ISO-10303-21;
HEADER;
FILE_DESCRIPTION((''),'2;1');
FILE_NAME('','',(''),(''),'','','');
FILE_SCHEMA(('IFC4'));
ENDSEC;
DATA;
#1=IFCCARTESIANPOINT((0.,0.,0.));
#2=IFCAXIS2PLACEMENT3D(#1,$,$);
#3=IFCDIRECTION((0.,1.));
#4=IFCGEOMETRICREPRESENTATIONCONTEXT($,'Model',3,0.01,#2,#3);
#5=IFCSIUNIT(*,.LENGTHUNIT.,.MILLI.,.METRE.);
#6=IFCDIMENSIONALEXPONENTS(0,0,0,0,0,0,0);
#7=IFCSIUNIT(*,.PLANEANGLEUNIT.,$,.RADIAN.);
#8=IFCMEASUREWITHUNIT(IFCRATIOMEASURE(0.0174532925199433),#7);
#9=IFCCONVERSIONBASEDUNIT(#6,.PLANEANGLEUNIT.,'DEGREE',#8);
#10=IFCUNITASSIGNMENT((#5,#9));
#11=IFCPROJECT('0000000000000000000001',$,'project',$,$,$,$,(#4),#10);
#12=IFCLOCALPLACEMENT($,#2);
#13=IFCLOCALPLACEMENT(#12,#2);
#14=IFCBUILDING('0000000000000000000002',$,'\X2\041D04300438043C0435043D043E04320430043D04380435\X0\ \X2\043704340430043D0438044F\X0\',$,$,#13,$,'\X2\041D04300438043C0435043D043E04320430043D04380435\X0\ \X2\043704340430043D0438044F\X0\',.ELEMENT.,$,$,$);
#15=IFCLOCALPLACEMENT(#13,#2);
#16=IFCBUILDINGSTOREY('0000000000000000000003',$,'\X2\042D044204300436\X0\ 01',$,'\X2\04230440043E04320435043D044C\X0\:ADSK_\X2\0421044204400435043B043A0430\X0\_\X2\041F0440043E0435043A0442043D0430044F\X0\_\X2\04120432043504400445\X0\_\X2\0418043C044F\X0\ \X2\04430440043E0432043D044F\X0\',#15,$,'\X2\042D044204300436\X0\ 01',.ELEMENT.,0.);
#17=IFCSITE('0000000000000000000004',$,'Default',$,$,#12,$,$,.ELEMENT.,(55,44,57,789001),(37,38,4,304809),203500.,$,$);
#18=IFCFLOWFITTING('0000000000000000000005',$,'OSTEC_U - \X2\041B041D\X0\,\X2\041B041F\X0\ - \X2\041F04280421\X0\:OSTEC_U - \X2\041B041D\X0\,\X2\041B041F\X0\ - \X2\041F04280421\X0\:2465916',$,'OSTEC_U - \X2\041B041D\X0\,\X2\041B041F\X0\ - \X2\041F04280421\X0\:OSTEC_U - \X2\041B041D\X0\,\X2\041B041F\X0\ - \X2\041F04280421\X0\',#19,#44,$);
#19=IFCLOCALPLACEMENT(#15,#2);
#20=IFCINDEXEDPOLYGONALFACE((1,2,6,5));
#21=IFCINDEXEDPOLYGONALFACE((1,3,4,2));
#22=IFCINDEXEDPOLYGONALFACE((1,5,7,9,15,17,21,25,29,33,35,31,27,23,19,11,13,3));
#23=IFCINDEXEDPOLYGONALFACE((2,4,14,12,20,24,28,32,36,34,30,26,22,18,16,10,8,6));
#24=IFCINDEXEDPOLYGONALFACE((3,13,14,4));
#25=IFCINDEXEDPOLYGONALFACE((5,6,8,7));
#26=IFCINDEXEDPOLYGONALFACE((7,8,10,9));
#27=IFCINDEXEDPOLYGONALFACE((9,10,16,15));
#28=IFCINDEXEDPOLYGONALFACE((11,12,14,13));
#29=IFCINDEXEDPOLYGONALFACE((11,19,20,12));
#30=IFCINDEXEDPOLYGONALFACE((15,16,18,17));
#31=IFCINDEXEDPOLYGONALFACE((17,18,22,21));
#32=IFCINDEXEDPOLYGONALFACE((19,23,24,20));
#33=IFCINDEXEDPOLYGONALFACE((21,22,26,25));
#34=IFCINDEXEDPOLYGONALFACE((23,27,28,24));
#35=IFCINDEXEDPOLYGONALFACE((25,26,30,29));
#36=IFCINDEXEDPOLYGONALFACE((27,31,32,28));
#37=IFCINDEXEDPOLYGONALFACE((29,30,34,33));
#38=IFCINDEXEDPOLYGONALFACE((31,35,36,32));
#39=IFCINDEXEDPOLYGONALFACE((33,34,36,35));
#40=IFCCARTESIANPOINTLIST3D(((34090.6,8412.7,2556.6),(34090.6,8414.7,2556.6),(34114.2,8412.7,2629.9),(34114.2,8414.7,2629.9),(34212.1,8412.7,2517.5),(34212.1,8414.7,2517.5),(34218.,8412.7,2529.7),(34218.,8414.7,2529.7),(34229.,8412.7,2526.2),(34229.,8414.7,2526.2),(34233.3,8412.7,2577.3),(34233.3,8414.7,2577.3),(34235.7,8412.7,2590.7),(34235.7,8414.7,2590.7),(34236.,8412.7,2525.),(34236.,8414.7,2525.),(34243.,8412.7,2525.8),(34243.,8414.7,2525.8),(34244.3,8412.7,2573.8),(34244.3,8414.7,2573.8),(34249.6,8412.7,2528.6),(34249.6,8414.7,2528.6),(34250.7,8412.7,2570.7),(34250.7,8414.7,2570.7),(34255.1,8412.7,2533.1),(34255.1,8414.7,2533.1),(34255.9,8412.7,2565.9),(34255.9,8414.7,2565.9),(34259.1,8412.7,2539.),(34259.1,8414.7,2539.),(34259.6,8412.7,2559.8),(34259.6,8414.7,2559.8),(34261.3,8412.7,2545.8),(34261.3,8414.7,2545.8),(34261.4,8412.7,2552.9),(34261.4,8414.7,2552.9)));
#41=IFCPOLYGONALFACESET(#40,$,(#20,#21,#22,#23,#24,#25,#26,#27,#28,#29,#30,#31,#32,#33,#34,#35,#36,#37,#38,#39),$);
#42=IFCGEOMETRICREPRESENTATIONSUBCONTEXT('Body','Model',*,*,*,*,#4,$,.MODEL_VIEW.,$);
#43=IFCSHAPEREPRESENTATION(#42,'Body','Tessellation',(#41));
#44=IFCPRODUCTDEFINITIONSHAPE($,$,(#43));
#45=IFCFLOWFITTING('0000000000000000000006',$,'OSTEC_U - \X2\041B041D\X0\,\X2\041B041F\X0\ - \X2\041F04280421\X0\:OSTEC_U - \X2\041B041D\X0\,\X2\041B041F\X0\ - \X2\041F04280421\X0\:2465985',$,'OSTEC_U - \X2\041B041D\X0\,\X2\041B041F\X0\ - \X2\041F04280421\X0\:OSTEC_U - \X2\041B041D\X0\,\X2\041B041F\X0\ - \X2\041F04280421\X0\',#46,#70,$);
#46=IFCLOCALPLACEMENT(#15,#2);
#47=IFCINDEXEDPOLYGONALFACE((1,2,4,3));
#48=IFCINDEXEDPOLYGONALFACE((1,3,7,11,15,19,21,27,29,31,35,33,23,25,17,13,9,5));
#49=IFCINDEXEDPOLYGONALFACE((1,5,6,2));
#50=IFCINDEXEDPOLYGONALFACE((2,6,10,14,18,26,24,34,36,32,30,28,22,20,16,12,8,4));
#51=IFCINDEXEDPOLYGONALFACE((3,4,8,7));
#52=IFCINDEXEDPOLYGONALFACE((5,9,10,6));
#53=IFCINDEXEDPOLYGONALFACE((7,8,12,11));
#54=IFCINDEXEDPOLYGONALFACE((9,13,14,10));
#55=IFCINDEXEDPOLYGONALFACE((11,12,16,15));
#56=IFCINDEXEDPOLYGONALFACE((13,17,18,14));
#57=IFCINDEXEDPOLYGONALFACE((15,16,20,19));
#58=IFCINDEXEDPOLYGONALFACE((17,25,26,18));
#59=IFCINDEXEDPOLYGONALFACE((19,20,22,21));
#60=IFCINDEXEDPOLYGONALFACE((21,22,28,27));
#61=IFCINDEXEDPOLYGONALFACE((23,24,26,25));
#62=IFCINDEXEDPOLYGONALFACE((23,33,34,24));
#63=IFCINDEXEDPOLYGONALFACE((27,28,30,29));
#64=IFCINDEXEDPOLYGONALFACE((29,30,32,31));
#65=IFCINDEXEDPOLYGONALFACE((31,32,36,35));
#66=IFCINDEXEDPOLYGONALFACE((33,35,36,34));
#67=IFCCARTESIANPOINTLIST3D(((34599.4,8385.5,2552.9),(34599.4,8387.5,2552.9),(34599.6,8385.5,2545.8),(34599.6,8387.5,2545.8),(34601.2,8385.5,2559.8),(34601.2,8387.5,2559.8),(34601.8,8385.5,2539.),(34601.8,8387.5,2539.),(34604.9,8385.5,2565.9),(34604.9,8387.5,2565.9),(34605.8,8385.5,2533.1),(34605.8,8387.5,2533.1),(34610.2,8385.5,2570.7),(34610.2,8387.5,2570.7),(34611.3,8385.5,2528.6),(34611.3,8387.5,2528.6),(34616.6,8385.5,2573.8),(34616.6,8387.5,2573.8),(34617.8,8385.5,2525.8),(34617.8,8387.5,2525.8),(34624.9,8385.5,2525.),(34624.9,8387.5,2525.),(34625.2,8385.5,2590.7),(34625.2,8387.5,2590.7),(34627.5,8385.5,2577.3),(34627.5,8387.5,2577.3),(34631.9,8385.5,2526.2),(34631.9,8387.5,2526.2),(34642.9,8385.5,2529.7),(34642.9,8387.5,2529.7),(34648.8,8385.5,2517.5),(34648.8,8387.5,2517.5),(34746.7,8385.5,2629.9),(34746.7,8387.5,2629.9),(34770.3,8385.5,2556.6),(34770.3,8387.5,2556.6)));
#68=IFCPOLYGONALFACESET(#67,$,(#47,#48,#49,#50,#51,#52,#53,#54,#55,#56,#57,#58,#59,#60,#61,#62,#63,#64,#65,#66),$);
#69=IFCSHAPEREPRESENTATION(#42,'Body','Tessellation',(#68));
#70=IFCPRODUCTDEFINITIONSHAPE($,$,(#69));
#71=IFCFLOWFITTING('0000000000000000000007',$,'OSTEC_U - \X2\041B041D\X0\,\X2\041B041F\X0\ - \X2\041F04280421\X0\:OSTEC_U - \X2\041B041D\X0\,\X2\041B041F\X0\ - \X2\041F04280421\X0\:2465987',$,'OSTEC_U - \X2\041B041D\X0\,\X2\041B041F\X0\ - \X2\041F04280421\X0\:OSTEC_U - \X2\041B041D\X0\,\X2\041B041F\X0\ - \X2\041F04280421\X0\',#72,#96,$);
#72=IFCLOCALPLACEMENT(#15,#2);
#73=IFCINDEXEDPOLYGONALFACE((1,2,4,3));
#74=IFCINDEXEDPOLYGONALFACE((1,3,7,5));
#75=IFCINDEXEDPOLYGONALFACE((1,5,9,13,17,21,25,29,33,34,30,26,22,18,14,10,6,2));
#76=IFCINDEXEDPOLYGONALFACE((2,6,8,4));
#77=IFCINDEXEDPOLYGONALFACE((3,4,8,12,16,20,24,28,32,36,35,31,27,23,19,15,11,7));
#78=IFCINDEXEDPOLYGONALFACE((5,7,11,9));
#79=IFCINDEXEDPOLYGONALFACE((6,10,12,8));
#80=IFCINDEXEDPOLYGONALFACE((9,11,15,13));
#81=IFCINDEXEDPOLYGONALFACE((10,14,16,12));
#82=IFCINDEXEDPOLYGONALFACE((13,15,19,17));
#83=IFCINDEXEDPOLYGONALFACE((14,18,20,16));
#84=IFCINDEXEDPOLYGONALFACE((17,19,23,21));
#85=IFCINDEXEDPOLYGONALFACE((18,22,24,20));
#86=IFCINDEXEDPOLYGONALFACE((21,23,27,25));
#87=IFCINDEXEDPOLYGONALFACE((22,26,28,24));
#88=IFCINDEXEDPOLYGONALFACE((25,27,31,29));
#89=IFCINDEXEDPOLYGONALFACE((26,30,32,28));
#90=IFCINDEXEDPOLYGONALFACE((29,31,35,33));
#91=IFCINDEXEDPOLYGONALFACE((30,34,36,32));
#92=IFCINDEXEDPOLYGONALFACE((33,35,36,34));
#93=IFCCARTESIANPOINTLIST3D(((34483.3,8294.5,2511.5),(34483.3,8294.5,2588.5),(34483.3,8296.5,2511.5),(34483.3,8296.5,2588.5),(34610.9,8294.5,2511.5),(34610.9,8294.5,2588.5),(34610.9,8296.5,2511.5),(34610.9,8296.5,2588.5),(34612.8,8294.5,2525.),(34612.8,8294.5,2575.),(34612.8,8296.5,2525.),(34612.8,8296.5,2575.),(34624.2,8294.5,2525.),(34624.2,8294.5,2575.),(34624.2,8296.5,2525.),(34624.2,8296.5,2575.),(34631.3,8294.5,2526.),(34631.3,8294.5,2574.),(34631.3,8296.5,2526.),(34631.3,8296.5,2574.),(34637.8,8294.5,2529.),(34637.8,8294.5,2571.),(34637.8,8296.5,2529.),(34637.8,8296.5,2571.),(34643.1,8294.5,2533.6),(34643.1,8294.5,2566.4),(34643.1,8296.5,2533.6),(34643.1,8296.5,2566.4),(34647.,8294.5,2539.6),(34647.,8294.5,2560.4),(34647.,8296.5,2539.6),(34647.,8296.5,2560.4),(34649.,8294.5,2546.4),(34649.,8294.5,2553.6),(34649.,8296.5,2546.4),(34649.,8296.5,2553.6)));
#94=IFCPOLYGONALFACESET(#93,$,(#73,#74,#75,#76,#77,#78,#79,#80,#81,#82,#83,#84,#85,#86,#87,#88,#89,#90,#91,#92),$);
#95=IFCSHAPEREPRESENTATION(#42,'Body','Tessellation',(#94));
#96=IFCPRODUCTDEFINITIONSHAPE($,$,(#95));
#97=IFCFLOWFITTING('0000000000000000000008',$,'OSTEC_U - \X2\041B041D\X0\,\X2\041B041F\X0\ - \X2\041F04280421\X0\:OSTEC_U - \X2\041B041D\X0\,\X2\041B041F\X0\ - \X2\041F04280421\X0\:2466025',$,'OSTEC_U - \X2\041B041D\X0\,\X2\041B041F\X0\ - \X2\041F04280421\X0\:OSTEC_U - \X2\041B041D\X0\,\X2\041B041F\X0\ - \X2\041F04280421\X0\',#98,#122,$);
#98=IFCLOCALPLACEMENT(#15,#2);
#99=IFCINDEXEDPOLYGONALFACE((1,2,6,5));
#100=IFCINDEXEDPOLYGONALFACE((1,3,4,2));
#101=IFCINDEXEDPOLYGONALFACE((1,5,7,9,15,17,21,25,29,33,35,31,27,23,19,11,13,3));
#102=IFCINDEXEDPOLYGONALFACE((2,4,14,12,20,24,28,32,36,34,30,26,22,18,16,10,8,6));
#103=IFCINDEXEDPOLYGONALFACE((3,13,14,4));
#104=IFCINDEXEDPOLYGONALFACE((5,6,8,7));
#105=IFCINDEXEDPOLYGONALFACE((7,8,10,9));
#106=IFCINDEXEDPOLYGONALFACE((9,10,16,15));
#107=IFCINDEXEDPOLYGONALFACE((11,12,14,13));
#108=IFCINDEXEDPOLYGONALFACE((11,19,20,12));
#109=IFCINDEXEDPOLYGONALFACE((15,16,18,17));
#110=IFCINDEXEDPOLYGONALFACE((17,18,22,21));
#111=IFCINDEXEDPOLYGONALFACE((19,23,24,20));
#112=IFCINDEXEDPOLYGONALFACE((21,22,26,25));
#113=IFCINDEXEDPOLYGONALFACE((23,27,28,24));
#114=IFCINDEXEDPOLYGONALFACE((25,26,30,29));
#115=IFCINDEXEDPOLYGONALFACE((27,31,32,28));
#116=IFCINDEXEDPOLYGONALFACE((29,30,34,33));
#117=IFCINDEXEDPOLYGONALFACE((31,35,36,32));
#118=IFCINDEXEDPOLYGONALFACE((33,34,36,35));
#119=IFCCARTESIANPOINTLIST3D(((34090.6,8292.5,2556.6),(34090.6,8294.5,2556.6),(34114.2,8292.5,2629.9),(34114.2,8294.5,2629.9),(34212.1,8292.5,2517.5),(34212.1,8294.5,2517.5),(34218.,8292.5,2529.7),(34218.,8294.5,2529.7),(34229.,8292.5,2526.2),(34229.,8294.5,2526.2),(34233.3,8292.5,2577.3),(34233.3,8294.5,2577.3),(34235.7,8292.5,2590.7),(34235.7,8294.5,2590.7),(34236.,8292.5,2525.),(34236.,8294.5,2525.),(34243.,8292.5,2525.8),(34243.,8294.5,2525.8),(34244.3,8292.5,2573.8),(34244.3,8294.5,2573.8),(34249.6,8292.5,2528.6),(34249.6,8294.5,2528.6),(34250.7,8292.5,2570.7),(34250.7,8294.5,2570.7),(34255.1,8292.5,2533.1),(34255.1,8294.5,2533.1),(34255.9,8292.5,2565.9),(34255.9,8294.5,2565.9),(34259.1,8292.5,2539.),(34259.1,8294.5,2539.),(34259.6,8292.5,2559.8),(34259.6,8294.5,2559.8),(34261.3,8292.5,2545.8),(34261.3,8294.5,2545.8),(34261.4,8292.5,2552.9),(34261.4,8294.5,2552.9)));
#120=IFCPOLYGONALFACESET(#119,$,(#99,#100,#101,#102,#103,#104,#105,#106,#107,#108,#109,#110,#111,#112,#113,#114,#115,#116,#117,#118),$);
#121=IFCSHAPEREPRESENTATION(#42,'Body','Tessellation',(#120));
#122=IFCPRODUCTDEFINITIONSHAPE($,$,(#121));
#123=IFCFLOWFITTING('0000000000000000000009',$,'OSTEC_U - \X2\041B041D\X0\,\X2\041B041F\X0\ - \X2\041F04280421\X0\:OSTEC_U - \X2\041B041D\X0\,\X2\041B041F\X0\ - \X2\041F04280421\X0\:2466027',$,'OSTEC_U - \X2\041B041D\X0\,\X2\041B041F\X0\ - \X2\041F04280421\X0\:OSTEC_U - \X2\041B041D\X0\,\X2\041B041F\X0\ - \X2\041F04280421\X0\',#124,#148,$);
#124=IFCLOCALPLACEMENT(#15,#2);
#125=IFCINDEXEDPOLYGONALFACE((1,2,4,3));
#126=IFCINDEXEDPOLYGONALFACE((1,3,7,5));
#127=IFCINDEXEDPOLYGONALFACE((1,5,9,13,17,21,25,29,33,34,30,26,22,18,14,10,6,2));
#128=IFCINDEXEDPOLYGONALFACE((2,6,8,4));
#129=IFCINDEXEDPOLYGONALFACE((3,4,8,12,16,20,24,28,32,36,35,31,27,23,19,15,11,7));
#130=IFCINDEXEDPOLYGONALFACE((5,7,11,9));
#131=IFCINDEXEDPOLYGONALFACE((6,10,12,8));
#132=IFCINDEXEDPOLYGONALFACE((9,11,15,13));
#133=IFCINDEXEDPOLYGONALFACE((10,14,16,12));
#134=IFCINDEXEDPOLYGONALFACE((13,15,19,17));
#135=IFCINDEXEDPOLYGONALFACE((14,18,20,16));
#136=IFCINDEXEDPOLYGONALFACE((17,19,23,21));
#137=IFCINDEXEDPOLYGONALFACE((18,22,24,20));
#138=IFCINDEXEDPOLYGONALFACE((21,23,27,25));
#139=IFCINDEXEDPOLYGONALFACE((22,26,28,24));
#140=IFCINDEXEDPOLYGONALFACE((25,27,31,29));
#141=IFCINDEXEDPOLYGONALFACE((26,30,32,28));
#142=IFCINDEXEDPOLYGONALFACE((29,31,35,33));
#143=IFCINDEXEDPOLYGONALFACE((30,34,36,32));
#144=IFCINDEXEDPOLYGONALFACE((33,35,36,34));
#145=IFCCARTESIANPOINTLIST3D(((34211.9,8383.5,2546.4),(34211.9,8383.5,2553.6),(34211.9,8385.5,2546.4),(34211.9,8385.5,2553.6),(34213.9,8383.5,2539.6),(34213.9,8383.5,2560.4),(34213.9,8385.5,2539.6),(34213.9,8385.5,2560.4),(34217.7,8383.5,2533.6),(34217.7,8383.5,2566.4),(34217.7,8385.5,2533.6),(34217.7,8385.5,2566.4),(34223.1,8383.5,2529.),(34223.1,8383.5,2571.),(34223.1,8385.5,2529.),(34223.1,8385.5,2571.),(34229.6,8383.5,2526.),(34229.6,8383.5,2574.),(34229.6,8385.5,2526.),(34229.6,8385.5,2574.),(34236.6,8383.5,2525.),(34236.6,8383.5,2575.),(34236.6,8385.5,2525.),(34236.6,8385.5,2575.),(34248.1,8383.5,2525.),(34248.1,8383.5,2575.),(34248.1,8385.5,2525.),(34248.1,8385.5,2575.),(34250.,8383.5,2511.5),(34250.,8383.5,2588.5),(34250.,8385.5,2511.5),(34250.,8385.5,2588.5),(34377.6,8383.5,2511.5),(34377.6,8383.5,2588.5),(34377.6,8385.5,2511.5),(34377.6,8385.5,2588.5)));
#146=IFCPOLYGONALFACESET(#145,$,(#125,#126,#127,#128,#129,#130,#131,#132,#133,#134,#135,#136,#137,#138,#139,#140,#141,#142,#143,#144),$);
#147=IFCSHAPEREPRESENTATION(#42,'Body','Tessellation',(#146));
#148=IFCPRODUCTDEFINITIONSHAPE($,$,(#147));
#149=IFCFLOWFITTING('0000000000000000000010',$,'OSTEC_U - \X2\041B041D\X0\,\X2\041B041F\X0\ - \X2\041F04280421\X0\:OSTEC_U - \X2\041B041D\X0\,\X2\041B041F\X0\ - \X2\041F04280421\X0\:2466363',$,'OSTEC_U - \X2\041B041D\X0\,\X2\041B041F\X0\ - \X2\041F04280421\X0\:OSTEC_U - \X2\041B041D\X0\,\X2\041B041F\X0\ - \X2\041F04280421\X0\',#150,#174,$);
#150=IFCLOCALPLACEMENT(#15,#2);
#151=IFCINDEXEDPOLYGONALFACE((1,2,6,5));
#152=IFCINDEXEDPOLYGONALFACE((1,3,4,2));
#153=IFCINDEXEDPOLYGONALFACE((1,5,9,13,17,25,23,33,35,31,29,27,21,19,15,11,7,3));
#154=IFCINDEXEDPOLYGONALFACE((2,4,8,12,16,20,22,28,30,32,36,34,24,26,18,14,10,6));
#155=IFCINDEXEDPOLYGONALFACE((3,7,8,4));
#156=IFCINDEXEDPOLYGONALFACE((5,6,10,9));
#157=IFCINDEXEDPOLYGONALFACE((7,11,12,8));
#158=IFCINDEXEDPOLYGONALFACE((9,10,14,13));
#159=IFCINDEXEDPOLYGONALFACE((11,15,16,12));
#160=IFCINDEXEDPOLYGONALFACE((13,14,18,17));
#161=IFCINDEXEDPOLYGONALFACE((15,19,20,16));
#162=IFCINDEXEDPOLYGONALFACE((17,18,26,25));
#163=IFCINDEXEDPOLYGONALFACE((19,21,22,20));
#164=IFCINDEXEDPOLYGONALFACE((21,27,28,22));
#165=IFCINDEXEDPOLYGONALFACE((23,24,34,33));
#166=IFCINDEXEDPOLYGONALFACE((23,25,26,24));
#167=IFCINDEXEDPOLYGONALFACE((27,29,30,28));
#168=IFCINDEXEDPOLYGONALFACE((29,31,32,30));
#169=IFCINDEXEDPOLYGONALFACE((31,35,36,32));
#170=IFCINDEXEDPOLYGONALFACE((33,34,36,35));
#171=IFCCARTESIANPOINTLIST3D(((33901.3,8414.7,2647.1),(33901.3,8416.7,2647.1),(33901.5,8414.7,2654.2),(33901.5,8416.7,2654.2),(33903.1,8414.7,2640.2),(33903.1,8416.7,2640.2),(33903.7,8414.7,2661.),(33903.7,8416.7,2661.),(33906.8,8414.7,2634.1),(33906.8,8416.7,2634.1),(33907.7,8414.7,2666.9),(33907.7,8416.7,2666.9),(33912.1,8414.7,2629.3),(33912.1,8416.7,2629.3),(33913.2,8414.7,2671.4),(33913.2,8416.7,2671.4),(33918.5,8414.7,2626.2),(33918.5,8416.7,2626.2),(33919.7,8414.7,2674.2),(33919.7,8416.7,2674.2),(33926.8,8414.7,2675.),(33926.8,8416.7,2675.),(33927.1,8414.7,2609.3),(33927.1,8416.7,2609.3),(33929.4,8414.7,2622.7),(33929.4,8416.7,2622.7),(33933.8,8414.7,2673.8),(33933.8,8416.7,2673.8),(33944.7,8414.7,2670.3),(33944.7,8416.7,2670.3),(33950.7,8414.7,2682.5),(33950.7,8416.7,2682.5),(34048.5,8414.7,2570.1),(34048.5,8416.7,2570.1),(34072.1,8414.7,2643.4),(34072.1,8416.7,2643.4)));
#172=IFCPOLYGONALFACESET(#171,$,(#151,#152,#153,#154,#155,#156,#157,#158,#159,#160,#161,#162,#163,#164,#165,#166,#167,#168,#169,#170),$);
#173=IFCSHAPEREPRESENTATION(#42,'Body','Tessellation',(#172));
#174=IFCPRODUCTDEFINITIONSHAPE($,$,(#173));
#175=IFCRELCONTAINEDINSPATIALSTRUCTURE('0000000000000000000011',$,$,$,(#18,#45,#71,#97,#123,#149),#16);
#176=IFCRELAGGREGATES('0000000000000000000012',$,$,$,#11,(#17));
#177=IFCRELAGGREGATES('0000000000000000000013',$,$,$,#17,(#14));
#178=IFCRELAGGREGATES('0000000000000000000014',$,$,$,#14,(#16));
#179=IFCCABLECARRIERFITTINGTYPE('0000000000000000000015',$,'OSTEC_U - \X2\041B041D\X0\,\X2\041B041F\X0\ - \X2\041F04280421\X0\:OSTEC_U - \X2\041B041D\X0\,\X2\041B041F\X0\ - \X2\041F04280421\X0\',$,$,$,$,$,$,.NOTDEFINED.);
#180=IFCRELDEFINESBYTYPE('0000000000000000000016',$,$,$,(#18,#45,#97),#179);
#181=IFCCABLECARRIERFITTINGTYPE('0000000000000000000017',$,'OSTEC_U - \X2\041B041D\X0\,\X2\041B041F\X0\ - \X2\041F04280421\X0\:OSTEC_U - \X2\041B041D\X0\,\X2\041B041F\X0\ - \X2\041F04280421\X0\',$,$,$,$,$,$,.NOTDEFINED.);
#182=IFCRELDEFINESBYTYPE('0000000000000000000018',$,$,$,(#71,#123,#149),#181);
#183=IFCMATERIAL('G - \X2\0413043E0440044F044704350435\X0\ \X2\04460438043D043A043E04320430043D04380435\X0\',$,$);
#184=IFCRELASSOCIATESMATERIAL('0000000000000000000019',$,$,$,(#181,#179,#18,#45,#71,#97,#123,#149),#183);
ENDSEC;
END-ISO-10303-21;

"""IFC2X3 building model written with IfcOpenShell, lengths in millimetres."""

from ifc_helpers import new_model, entity, si_unit, converted_unit, direction, frame, frame_2d, origin, place, context, subcontext, project, spatial, polyline, circle_curve, parameter, trimmed, segment, composite_curve, outline, extrude, source, transform, mapped, material, type_object, type_shapes, element, save


model = new_model("IFC2X3")

# Units and contexts
model_context = context("Model", 3, precision=0.01, world=origin(), true_north=direction((0.0, 1.0)))
body_context = subcontext(model_context, "Body", "Model", "MODEL_VIEW")
ifc_project = project(units=[si_unit("LENGTHUNIT", "METRE", prefix="MILLI"), converted_unit("PLANEANGLEUNIT", "DEGREE", entity("IfcRatioMeasure", 0.0174532925199433), si_unit("PLANEANGLEUNIT", "RADIAN"), dimensions=[0, 0, 0, 0, 0, 0, 0])], contexts=[model_context])

# Site, building, storey
site_placement = place(None, origin())
site = spatial("IfcSite", under=ifc_project, at=site_placement, Name="Default", CompositionType="ELEMENT", RefLatitude=(55, 44, 57, 789001), RefLongitude=(37, 38, 4, 304809), RefElevation=203500.0)
building_placement = place(site_placement, origin())
building = spatial("IfcBuilding", under=site, at=building_placement, Name="Наименование здания", LongName="Наименование здания", CompositionType="ELEMENT")
storey_placement = place(building_placement, origin())
storey = spatial("IfcBuildingStorey", under=building, at=storey_placement, Name="Этаж 01", ObjectType="Уровень:ADSK_Стрелка_Проектная_Вверх_Имя уровня", LongName="Этаж 01", CompositionType="ELEMENT", Elevation=0.0)

# Flow fittings
ifc_material = material(Name="G - Горячее цинкование")
cable_carrier_fitting_type_1 = type_object("IfcCableCarrierFittingType", Name="OSTEC_U - ЛН,ЛП - ПШС:OSTEC_U - ЛН,ЛП - ПШС", PredefinedType="NOTDEFINED", material=ifc_material)
shared_shape_1 = source(origin(), body_context, "Body", "SweptSolid", [
    extrude(outline(composite_curve([segment(trimmed(circle_curve(frame_2d((-41.5, 0.0), x_axis=(1.0, 0.0)), 25.0), [parameter(90.0)], [parameter(270.0)], True, "PARAMETER"), True, "CONTINUOUS"), segment(polyline([(-41.5, -25.0), (-30.0, -25.0)]), True, "CONTINUOUS"), segment(polyline([(-30.0, -25.0), (-28.1, -38.5)]), True, "CONTINUOUS"), segment(polyline([(-28.1, -38.5), (99.5, -38.5)]), True, "CONTINUOUS"), segment(polyline([(99.5, -38.5), (99.5, 38.5)]), True, "CONTINUOUS"), segment(polyline([(99.5, 38.5), (-28.1, 38.5)]), True, "CONTINUOUS"), segment(polyline([(-28.1, 38.5), (-30.0, 25.0)]), True, "CONTINUOUS"), segment(polyline([(-30.0, 25.0), (-41.5, 25.0)]), True, "CONTINUOUS")], self_intersect=False)), frame((41.5, 0.0, 0.0)), (0.0, 0.0, 1.0), 2.0),
])
type_shapes(cable_carrier_fitting_type_1, [shared_shape_1])
cable_carrier_fitting_type_2 = type_object("IfcCableCarrierFittingType", Name="OSTEC_U - ЛН,ЛП - ПШС:OSTEC_U - ЛН,ЛП - ПШС", PredefinedType="NOTDEFINED", material=ifc_material)
type_shapes(cable_carrier_fitting_type_2, [shared_shape_1])
for number, where, z_axis, x_axis, name in (
    (1, (34236.6, 8414.7, 2550.0), (0.0, -1.0, 0.0), (-0.951851, 0.0, 0.30656), "OSTEC_U - ЛН,ЛП - ПШС:OSTEC_U - ЛН,ЛП - ПШС:2465916"),
    (2, (34624.2, 8385.5, 2550.0), (0.0, 1.0, 0.0), (0.951851, 0.0, 0.30656), "OSTEC_U - ЛН,ЛП - ПШС:OSTEC_U - ЛН,ЛП - ПШС:2465985"),
):
    element("IfcFlowFitting", number, at=place(storey_placement, frame(where, z_axis=z_axis, x_axis=x_axis)), inside=storey, type_object=cable_carrier_fitting_type_2, material=ifc_material, Name=name, ObjectType="OSTEC_U - ЛН,ЛП - ПШС:OSTEC_U - ЛН,ЛП - ПШС", context=body_context, shape_type="MappedRepresentation", body=[
        mapped(shared_shape_1, transform((0.0, 0.0, 0.0), scale=1.0)),
    ])
flow_fitting_1_placement = place(storey_placement, frame((34624.2, 8296.5, 2550.0), z_axis=(0.0, -1.0, 0.0), x_axis=(-1.0, 0.0, 0.0)))
element("IfcFlowFitting", 3, at=flow_fitting_1_placement, inside=storey, type_object=cable_carrier_fitting_type_1, material=ifc_material, Name="OSTEC_U - ЛН,ЛП - ПШС:OSTEC_U - ЛН,ЛП - ПШС:2465987", ObjectType="OSTEC_U - ЛН,ЛП - ПШС:OSTEC_U - ЛН,ЛП - ПШС", context=body_context, shape_type="MappedRepresentation", body=[
    mapped(shared_shape_1, transform((0.0, 0.0, 0.0), scale=1.0)),
])
flow_fitting_2_placement = place(storey_placement, frame((34236.6, 8294.5, 2550.0), z_axis=(0.0, -1.0, 0.0), x_axis=(-0.951851, 0.0, 0.30656)))
element("IfcFlowFitting", 4, at=flow_fitting_2_placement, inside=storey, type_object=cable_carrier_fitting_type_2, material=ifc_material, Name="OSTEC_U - ЛН,ЛП - ПШС:OSTEC_U - ЛН,ЛП - ПШС:2466025", ObjectType="OSTEC_U - ЛН,ЛП - ПШС:OSTEC_U - ЛН,ЛП - ПШС", context=body_context, shape_type="MappedRepresentation", body=[
    mapped(shared_shape_1, transform((0.0, 0.0, 0.0), scale=1.0)),
])
for number, where, z_axis, x_axis, name in (
    (5, (34236.6, 8383.5, 2550.0), (0.0, 1.0, 0.0), (1.0, 0.0, 0.0), "OSTEC_U - ЛН,ЛП - ПШС:OSTEC_U - ЛН,ЛП - ПШС:2466027"),
    (6, (33926.1, 8416.7, 2650.0), (0.0, -1.0, 0.0), (0.951851, 0.0, -0.30656), "OSTEC_U - ЛН,ЛП - ПШС:OSTEC_U - ЛН,ЛП - ПШС:2466363"),
):
    element("IfcFlowFitting", number, at=place(storey_placement, frame(where, z_axis=z_axis, x_axis=x_axis)), inside=storey, type_object=cable_carrier_fitting_type_1, material=ifc_material, Name=name, ObjectType="OSTEC_U - ЛН,ЛП - ПШС:OSTEC_U - ЛН,ЛП - ПШС", context=body_context, shape_type="MappedRepresentation", body=[
        mapped(shared_shape_1, transform((0.0, 0.0, 0.0), scale=1.0)),
    ])

save(model, "model.ifc")
